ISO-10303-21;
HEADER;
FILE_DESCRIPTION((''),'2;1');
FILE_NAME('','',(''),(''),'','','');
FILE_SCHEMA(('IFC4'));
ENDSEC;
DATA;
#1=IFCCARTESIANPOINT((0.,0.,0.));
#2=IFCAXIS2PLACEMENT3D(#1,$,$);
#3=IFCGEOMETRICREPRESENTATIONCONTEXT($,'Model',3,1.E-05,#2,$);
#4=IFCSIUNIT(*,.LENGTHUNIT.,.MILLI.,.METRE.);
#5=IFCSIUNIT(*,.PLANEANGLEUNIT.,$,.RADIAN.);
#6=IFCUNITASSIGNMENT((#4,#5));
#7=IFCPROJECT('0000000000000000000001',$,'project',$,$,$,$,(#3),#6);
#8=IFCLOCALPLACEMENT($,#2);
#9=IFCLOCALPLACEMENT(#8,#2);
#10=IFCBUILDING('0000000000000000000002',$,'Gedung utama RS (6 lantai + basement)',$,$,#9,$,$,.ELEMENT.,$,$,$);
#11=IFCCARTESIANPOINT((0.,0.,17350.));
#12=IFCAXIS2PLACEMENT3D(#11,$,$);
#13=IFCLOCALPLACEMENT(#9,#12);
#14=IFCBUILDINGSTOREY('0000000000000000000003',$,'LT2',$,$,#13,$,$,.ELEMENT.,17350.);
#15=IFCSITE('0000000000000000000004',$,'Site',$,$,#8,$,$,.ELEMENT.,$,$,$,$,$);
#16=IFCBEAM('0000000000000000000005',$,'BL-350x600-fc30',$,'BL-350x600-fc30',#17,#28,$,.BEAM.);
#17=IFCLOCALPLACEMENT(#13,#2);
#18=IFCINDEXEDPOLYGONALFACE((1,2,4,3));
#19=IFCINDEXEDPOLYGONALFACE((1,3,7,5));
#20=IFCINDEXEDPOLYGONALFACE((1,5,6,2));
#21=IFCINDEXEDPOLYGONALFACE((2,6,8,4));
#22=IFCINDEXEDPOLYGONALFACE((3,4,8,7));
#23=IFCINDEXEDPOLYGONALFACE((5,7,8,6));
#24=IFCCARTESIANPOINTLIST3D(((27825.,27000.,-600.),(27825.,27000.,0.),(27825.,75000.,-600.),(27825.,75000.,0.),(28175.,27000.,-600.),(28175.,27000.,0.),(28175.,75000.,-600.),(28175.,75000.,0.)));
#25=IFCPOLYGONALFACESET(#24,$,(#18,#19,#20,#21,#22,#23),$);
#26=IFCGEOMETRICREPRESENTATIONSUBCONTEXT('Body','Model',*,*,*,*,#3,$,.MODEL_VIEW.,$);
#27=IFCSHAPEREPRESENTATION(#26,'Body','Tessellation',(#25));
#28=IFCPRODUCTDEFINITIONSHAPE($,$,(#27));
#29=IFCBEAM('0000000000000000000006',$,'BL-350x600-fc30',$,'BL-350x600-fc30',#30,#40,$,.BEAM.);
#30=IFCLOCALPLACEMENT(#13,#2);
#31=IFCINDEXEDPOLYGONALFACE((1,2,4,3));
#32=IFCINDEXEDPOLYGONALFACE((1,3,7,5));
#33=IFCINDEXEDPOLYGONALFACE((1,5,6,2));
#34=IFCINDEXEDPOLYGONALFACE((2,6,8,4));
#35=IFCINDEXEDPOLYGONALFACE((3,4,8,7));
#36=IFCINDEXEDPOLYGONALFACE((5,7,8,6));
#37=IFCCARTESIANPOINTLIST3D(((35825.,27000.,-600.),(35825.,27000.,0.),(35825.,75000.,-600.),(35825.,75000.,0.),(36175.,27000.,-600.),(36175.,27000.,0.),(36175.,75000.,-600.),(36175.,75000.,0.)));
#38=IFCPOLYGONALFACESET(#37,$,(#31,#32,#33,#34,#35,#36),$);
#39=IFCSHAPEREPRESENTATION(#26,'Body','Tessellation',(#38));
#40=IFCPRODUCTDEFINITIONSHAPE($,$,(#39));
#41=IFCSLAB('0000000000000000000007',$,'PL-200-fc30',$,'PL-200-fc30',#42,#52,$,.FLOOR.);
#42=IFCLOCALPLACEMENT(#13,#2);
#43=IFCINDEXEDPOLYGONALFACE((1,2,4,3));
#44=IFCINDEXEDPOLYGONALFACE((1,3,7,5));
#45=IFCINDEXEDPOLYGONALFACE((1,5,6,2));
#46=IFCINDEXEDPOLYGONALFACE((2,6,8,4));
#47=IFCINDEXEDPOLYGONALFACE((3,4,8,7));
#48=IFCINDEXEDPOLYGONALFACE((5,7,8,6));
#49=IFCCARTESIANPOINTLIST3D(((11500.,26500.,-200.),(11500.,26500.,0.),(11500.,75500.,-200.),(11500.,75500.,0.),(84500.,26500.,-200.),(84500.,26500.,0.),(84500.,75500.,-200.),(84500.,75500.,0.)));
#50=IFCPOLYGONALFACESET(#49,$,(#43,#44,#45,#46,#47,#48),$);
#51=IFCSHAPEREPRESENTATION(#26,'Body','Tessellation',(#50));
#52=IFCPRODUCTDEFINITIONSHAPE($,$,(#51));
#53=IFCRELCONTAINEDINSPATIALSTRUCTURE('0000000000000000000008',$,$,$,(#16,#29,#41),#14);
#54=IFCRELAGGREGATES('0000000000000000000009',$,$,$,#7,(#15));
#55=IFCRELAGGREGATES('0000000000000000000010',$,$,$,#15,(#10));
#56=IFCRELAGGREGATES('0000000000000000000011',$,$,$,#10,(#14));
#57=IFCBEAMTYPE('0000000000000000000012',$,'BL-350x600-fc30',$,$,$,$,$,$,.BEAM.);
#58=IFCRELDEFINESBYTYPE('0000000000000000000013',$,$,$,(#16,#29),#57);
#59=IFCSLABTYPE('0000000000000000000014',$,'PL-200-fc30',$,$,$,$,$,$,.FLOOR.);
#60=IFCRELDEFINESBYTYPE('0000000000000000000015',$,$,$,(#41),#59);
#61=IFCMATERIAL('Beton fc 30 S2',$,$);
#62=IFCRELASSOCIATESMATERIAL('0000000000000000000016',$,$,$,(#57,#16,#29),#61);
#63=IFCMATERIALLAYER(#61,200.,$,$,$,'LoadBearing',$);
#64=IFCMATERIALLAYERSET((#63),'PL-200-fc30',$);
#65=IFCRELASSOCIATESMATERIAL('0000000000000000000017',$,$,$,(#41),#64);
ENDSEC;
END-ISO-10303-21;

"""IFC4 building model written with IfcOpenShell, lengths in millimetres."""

from ifc_helpers import new_model, si_unit, frame, origin, origin_2d, place, context, subcontext, project, spatial, polyline, rectangle, outline, extrude, material, layer, layer_set, layer_usage, material_profile, profile_set, profile_usage, type_object, element, save


model = new_model("IFC4")

# Units and contexts
model_context = context("Model", 3, precision=1e-05, world=origin())
body_context = subcontext(model_context, "Body", "Model", "MODEL_VIEW")
ifc_project = project(units=[si_unit("LENGTHUNIT", "METRE", prefix="MILLI"), si_unit("PLANEANGLEUNIT", "RADIAN")], contexts=[model_context])

# Site, building, storey
site_placement = place(None, origin())
site = spatial("IfcSite", under=ifc_project, at=site_placement, Name="Site", CompositionType="ELEMENT")
building_placement = place(site_placement, origin())
building = spatial("IfcBuilding", under=site, at=building_placement, Name="Gedung utama RS (6 lantai + basement)", CompositionType="ELEMENT")
storey_placement = place(building_placement, frame((0.0, 0.0, 17350.0)))
storey = spatial("IfcBuildingStorey", under=building, at=storey_placement, Name="LT2", CompositionType="ELEMENT", Elevation=17350.0)

# Beams
ifc_material = material(Name="Beton fc 30 S2")
ifc_material_profile_1 = material_profile(ifc_material, rectangle(XDim=350.0, YDim=600.0, at=origin_2d()), Name="BL-350x600-fc30")
ifc_profile_set_1 = profile_set([ifc_material_profile_1], Name="BL-350x600-fc30")
ifc_profile_usage_1 = profile_usage(ifc_profile_set_1, cardinal=8)
beam_type = type_object("IfcBeamType", Name="BL-350x600-fc30", PredefinedType="BEAM", material=ifc_profile_set_1)
for number, where, name in (
    (1, (28000.0, 27000.0, -300.0), "BL-350x600-fc30"),
    (2, (36000.0, 27000.0, -300.0), "BL-350x600-fc30"),
):
    element("IfcBeam", number, at=place(storey_placement, frame(where)), inside=storey, type_object=beam_type, material=ifc_profile_usage_1, Name=name, ObjectType="BL-350x600-fc30", PredefinedType="BEAM", context=body_context, shape_type="SweptSolid", body=[
        extrude(rectangle(XDim=350.0, YDim=600.0, at=origin_2d()), frame((0.0, 0.0, 0.0), z_axis=(0.0, 1.0, 0.0), x_axis=(-1.0, 0.0, 0.0)), (0.0, 0.0, 1.0), 48000.0),
    ])

# Slab
ifc_layer = layer(ifc_material, 200.0, Category="LoadBearing")
ifc_layer_set = layer_set([ifc_layer], Name="PL-200-fc30")
ifc_layer_usage = layer_usage(ifc_layer_set, "AXIS3", "NEGATIVE", 0.0)
slab_type = type_object("IfcSlabType", Name="PL-200-fc30", PredefinedType="FLOOR")
slab_placement = place(storey_placement, origin())
element("IfcSlab", 3, at=slab_placement, inside=storey, type_object=slab_type, material=ifc_layer_usage, Name="PL-200-fc30", ObjectType="PL-200-fc30", PredefinedType="FLOOR", context=body_context, shape_type="SweptSolid", body=[
    extrude(outline(polyline([(11500.0, 26500.0), (84500.0, 26500.0), (84500.0, 75500.0), (11500.0, 75500.0), (11500.0, 26500.0)])), frame((0.0, 0.0, -200.0)), (0.0, 0.0, 1.0), 200.0),
])

save(model, "model.ifc")
